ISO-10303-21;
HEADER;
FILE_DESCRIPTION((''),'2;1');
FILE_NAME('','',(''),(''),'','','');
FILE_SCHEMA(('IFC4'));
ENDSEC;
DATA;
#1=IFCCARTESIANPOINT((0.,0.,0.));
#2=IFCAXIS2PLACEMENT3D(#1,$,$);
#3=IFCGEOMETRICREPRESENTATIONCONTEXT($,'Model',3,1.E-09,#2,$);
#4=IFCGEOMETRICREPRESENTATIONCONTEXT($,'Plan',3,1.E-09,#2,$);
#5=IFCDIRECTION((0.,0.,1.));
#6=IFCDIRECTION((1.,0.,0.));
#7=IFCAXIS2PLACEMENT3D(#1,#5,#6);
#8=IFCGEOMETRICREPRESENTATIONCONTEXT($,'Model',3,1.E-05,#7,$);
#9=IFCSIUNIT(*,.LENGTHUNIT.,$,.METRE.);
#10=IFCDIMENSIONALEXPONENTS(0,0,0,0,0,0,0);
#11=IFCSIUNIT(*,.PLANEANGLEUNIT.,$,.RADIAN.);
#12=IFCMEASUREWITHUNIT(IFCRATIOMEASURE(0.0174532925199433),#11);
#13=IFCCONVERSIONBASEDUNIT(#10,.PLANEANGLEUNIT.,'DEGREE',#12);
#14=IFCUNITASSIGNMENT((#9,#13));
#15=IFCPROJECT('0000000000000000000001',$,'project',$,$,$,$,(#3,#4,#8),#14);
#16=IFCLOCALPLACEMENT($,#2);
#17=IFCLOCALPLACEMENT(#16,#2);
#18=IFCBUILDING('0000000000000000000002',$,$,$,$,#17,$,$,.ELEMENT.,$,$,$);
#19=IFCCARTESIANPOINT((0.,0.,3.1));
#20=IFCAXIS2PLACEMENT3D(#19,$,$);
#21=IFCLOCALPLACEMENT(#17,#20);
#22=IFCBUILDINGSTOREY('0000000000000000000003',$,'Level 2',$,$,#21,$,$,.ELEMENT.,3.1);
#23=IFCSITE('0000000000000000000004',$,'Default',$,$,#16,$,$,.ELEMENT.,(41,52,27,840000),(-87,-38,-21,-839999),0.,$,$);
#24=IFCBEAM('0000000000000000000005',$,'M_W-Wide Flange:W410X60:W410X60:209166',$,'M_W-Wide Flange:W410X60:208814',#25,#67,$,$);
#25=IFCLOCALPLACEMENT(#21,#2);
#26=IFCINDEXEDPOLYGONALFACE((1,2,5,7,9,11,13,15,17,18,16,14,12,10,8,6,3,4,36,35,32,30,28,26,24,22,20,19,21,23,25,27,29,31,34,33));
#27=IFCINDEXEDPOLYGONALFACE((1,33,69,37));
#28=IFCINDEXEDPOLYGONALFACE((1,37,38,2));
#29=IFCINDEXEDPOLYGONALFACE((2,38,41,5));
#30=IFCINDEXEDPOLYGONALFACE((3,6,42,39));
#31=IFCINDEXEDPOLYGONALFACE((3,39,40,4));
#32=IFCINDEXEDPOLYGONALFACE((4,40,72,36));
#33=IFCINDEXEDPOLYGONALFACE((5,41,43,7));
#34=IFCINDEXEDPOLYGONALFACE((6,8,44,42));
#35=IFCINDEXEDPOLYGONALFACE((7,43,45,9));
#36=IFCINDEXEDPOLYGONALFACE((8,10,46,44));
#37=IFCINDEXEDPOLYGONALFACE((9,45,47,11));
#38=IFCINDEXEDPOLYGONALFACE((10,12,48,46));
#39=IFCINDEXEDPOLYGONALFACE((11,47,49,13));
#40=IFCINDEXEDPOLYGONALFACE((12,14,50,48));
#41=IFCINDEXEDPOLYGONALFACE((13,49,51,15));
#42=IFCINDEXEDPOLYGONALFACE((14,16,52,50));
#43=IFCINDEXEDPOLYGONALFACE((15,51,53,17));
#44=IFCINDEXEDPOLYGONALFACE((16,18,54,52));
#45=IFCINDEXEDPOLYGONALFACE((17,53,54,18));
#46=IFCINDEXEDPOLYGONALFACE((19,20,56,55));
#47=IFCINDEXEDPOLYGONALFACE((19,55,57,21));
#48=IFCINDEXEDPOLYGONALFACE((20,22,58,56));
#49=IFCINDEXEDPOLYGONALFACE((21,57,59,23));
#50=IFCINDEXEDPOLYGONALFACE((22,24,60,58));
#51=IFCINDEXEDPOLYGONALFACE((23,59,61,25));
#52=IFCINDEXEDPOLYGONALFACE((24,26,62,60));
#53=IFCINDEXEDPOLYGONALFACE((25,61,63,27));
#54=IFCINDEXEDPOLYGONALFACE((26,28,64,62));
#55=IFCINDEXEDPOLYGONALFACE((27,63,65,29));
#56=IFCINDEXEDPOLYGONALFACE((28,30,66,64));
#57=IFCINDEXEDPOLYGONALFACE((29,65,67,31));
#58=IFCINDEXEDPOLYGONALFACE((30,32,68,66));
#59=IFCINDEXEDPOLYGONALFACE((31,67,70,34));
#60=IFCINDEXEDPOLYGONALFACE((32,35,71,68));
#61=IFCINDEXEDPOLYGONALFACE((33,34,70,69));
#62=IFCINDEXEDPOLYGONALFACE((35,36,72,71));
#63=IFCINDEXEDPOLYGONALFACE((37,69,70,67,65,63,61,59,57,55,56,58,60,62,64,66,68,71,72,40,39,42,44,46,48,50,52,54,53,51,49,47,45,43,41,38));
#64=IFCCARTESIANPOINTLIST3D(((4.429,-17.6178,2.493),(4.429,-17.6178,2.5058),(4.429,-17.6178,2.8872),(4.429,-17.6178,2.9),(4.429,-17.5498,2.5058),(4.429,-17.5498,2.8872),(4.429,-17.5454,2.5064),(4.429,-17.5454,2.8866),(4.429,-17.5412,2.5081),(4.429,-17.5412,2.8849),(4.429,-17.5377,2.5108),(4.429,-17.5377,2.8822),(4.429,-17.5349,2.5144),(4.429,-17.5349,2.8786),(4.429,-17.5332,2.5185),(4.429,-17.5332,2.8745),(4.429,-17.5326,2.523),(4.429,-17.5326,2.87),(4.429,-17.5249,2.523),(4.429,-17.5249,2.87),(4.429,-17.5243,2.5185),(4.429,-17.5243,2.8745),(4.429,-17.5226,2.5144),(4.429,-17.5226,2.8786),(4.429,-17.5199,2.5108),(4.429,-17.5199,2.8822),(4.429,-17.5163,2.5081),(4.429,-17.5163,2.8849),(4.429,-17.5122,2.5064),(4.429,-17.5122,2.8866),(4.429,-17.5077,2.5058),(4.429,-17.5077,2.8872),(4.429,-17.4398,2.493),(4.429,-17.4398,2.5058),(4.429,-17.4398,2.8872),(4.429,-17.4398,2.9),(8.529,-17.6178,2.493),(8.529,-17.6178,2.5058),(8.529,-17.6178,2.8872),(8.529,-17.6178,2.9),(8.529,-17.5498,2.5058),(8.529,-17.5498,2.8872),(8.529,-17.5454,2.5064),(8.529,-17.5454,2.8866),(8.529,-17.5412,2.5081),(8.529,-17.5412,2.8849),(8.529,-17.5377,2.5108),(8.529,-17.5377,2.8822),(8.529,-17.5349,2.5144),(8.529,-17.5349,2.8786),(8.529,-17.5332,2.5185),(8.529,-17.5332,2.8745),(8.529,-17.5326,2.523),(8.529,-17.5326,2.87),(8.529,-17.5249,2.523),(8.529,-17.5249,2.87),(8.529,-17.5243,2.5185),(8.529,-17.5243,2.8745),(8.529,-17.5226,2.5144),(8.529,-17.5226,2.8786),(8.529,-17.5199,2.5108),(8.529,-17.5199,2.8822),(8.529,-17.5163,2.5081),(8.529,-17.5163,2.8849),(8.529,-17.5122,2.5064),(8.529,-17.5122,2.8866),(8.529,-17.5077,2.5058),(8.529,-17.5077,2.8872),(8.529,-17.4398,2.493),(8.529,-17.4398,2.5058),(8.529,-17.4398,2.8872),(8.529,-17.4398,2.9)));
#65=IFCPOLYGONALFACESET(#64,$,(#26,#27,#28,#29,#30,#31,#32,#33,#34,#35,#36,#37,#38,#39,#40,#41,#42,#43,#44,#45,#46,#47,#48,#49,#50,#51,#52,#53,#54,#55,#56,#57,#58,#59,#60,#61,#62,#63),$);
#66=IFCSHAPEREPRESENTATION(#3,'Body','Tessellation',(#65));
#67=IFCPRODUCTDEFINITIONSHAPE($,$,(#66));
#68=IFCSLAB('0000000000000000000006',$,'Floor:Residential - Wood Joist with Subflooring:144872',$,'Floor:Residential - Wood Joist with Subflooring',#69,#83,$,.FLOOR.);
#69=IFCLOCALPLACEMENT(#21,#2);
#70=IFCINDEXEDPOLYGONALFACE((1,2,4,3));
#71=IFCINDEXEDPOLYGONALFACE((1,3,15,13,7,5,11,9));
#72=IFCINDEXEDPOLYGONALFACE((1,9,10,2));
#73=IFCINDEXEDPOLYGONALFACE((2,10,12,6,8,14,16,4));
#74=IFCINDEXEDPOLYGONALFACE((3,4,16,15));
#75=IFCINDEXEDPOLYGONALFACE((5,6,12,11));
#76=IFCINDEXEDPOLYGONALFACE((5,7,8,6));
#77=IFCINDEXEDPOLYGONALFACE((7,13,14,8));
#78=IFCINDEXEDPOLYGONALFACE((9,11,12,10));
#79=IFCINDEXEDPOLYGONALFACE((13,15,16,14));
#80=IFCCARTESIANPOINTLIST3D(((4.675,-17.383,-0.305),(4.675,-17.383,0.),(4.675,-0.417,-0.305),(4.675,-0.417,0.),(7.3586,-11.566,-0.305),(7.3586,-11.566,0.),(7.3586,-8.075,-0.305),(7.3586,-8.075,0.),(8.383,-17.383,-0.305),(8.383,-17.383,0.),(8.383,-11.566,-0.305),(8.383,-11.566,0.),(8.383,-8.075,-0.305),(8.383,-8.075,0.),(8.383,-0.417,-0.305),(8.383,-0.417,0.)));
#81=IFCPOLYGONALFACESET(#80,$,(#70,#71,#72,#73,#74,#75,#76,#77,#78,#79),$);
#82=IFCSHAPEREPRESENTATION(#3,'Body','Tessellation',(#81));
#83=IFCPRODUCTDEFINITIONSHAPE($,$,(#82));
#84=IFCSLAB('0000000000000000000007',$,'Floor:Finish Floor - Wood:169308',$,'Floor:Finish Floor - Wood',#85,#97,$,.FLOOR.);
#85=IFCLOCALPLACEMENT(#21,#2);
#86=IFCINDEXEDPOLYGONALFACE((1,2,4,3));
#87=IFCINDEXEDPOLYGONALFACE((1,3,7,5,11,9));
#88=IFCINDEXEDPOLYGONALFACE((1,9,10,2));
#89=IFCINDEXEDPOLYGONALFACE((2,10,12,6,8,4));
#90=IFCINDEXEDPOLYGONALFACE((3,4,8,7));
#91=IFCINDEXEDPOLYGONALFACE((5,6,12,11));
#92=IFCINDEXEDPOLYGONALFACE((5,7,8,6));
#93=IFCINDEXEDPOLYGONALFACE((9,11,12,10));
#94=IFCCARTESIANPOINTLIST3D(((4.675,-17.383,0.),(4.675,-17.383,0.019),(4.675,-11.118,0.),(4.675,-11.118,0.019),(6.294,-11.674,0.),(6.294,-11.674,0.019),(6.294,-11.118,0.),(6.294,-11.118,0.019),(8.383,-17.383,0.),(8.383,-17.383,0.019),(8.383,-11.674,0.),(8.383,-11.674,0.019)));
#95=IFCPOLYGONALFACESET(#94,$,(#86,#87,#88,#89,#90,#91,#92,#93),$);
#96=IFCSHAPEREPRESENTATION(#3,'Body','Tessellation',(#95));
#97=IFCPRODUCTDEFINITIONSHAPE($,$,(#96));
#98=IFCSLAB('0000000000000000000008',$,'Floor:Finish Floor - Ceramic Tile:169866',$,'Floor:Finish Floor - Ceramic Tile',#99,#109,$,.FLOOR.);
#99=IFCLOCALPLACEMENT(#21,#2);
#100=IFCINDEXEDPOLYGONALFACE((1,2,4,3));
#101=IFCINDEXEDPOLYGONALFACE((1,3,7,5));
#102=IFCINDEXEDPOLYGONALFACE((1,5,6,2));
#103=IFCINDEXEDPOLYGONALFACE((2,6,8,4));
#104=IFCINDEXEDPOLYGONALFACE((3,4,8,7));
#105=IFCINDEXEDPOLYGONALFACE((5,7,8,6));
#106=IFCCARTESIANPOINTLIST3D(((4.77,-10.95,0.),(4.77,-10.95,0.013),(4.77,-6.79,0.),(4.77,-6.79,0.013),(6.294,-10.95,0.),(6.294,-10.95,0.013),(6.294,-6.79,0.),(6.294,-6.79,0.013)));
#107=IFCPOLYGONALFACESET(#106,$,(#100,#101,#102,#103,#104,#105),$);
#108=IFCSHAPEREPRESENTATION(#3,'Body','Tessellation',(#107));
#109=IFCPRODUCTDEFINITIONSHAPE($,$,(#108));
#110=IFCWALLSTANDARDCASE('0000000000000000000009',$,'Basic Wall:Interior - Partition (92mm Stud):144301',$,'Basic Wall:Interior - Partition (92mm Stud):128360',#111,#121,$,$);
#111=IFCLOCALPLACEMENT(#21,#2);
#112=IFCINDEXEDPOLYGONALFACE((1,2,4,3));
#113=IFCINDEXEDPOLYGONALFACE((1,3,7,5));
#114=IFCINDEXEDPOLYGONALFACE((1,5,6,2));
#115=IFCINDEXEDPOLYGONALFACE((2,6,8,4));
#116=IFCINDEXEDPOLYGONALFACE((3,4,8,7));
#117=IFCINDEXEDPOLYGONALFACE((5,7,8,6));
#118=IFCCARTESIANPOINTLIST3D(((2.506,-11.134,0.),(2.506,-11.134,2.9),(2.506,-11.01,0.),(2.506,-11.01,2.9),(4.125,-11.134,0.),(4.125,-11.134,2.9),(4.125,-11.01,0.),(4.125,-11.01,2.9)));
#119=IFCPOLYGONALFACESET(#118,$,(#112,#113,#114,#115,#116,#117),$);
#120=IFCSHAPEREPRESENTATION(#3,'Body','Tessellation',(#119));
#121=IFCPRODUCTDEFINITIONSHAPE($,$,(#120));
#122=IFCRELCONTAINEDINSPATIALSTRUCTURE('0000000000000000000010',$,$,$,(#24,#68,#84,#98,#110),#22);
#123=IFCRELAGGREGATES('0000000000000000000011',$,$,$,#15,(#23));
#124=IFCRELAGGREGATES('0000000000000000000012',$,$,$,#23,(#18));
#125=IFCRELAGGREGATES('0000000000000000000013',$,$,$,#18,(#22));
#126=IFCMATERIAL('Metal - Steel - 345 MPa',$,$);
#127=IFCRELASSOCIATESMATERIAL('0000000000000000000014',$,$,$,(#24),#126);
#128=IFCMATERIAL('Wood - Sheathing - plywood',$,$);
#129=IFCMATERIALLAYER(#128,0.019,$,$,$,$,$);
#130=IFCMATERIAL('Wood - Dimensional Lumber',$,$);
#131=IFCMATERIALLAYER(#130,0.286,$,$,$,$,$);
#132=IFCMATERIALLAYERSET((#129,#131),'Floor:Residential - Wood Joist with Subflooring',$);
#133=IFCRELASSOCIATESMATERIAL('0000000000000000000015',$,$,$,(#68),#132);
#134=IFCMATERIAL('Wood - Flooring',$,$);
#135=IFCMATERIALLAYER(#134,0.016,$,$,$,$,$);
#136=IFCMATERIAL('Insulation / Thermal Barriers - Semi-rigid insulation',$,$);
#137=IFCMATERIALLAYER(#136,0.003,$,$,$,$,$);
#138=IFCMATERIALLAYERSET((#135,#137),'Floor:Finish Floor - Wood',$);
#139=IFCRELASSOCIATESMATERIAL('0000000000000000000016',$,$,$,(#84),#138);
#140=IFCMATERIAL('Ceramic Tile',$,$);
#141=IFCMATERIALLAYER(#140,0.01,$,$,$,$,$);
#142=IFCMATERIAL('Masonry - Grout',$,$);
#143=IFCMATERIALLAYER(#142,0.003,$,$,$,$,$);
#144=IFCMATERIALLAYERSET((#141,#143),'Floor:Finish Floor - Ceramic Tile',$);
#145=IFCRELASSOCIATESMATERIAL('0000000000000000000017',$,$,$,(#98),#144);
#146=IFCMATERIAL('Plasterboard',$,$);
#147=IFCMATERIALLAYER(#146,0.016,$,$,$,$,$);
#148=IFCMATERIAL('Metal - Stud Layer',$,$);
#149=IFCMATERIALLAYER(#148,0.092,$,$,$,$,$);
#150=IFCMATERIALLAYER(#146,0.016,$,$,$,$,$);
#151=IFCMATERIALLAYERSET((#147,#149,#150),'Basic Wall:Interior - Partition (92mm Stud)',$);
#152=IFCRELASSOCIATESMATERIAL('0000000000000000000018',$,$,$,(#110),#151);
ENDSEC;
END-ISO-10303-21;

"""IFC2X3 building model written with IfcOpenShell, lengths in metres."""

from ifc_helpers import new_model, entity, si_unit, converted_unit, frame, frame_2d, origin, origin_with_axes, place, context, project, spatial, polyline, circle_curve, parameter, trimmed, segment, composite_curve, rectangle, outline, extrude, material, layer, layer_set, layer_usage, element, save


model = new_model("IFC2X3")

# Units and contexts
model_context_1 = context("Model", 3, precision=1e-09, world=origin())
plan_context = context("Plan", 3, precision=1e-09, world=origin())
model_context_2 = context("Model", 3, precision=1e-05, world=origin_with_axes())
ifc_project = project(units=[si_unit("LENGTHUNIT", "METRE"), converted_unit("PLANEANGLEUNIT", "DEGREE", entity("IfcRatioMeasure", 0.0174532925199433), si_unit("PLANEANGLEUNIT", "RADIAN"), dimensions=[0, 0, 0, 0, 0, 0, 0])], contexts=[model_context_1, plan_context, model_context_2])

# Site, building, storey
site_placement = place(None, origin())
site = spatial("IfcSite", under=ifc_project, at=site_placement, Name="Default", CompositionType="ELEMENT", RefLatitude=(41, 52, 27, 840000), RefLongitude=(-87, -38, -21, -839999), RefElevation=0.0)
building_placement = place(site_placement, origin())
building = spatial("IfcBuilding", under=site, at=building_placement, CompositionType="ELEMENT")
storey_placement = place(building_placement, frame((0.0, 0.0, 3.1)))
storey = spatial("IfcBuildingStorey", under=building, at=storey_placement, Name="Level 2", CompositionType="ELEMENT", Elevation=3.1)

# Beam
ifc_material_1 = material(Name="Metal - Steel - 345 MPa")
beam_placement = place(storey_placement, frame((4.429, -17.5288, 2.9), z_axis=(0.0, 0.0, 1.0), x_axis=(0.0, -1.0, 0.0)))
element("IfcBeam", 1, at=beam_placement, inside=storey, material=ifc_material_1, Name="M_W-Wide Flange:W410X60:W410X60:209166", ObjectType="M_W-Wide Flange:W410X60:208814", context=model_context_1, shape_type="SweptSolid", body=[
    extrude(outline(composite_curve([segment(polyline([(-0.089, -0.1907), (-0.089, -0.2035)]), True, "CONTINUOUS"), segment(polyline([(-0.089, -0.2035), (0.089, -0.2035)]), True, "CONTINUOUS"), segment(polyline([(0.089, -0.2035), (0.089, -0.1907)]), True, "CONTINUOUS"), segment(polyline([(0.089, -0.1907), (0.021, -0.1907)]), True, "CONTINUOUS"), segment(trimmed(circle_curve(frame_2d((0.021, -0.1735), x_axis=(0.0, -1.0)), 0.0172), [parameter(270.0)], [parameter(360.0)], True, "PARAMETER"), False, "CONTINUOUS"), segment(polyline([(0.0038, -0.1735), (0.0038, 0.1735)]), True, "CONTINUOUS"), segment(trimmed(circle_curve(frame_2d((0.021, 0.1735), x_axis=(-1.0, 0.0)), 0.0172), [parameter(270.0)], [parameter(360.0)], True, "PARAMETER"), False, "CONTINUOUS"), segment(polyline([(0.021, 0.1907), (0.089, 0.1907)]), True, "CONTINUOUS"), segment(polyline([(0.089, 0.1907), (0.089, 0.2035)]), True, "CONTINUOUS"), segment(polyline([(0.089, 0.2035), (-0.089, 0.2035)]), True, "CONTINUOUS"), segment(polyline([(-0.089, 0.2035), (-0.089, 0.1907)]), True, "CONTINUOUS"), segment(polyline([(-0.089, 0.1907), (-0.0211, 0.1907)]), True, "CONTINUOUS"), segment(trimmed(circle_curve(frame_2d((-0.0211, 0.1735), x_axis=(0.0, 1.0)), 0.0172), [parameter(270.0)], [parameter(0.0)], True, "PARAMETER"), False, "CONTINUOUS"), segment(polyline([(-0.0039, 0.1735), (-0.0039, -0.1735)]), True, "CONTINUOUS"), segment(trimmed(circle_curve(frame_2d((-0.0211, -0.1735), x_axis=(1.0, 0.0)), 0.0172), [parameter(270.0)], [parameter(0.0)], True, "PARAMETER"), False, "CONTINUOUS"), segment(polyline([(-0.0211, -0.1907), (-0.089, -0.1907)]), True, "CONTINUOUS")], self_intersect=False)), frame((0.0, 0.0, -0.2035), z_axis=(0.0, -1.0, 0.0), x_axis=(1.0, 0.0, 0.0)), (0.0, 0.0, -1.0), 4.1),
])

# Slabs
ifc_material_2 = material(Name="Wood - Sheathing - plywood")
ifc_layer_1 = layer(ifc_material_2, 0.019)
ifc_material_3 = material(Name="Wood - Dimensional Lumber")
ifc_layer_2 = layer(ifc_material_3, 0.286)
ifc_layer_set_1 = layer_set([ifc_layer_1, ifc_layer_2], Name="Floor:Residential - Wood Joist with Subflooring")
ifc_layer_usage_1 = layer_usage(ifc_layer_set_1, "AXIS3", "POSITIVE", 0.0)
slab_1_placement = place(storey_placement, frame((4.675, -17.383, -0.305)))
element("IfcSlab", 2, at=slab_1_placement, inside=storey, material=ifc_layer_usage_1, Name="Floor:Residential - Wood Joist with Subflooring:144872", ObjectType="Floor:Residential - Wood Joist with Subflooring", PredefinedType="FLOOR", context=model_context_1, shape_type="SweptSolid", body=[
    extrude(outline(polyline([(-1.854, 8.483), (-1.854, 0.825), (-0.8296, 0.825), (-0.8296, -2.666), (-1.854, -2.666), (-1.854, -8.483), (1.854, -8.483), (1.854, 8.483), (-1.854, 8.483)])), frame((1.854, 8.483, 0.305), z_axis=(0.0, 0.0, -1.0), x_axis=(-1.0, 0.0, 0.0)), (0.0, 0.0, 1.0), 0.305),
])
ifc_material_4 = material(Name="Wood - Flooring")
ifc_layer_3 = layer(ifc_material_4, 0.016)
ifc_material_5 = material(Name="Insulation / Thermal Barriers - Semi-rigid insulation")
ifc_layer_4 = layer(ifc_material_5, 0.003)
ifc_layer_set_2 = layer_set([ifc_layer_3, ifc_layer_4], Name="Floor:Finish Floor - Wood")
ifc_layer_usage_2 = layer_usage(ifc_layer_set_2, "AXIS3", "POSITIVE", 0.0)
slab_2_placement = place(storey_placement, frame((4.675, -17.383, 0.0)))
element("IfcSlab", 3, at=slab_2_placement, inside=storey, material=ifc_layer_usage_2, Name="Floor:Finish Floor - Wood:169308", ObjectType="Floor:Finish Floor - Wood", PredefinedType="FLOOR", context=model_context_1, shape_type="SweptSolid", body=[
    extrude(outline(polyline([(-1.854, 2.5765), (-1.854, -3.1325), (1.854, -3.1325), (1.854, 3.1325), (0.235, 3.1325), (0.235, 2.5765), (-1.854, 2.5765)])), frame((1.854, 3.1325, 0.019), z_axis=(0.0, 0.0, -1.0), x_axis=(-1.0, 0.0, 0.0)), (0.0, 0.0, 1.0), 0.019),
])
ifc_material_6 = material(Name="Ceramic Tile")
ifc_layer_5 = layer(ifc_material_6, 0.01)
ifc_material_7 = material(Name="Masonry - Grout")
ifc_layer_6 = layer(ifc_material_7, 0.003)
ifc_layer_set_3 = layer_set([ifc_layer_5, ifc_layer_6], Name="Floor:Finish Floor - Ceramic Tile")
ifc_layer_usage_3 = layer_usage(ifc_layer_set_3, "AXIS3", "POSITIVE", 0.0)
slab_3_placement = place(storey_placement, frame((4.77, -10.95, 0.0)))
element("IfcSlab", 4, at=slab_3_placement, inside=storey, material=ifc_layer_usage_3, Name="Floor:Finish Floor - Ceramic Tile:169866", ObjectType="Floor:Finish Floor - Ceramic Tile", PredefinedType="FLOOR", context=model_context_1, shape_type="SweptSolid", body=[
    extrude(rectangle(XDim=4.16, YDim=1.524, at=frame_2d((0.0, 0.0), x_axis=(0.0, -1.0))), frame((0.762, 2.08, 0.013), z_axis=(0.0, 0.0, -1.0), x_axis=(-1.0, 0.0, 0.0)), (0.0, 0.0, 1.0), 0.013),
])

# Shared definitions
ifc_material_8 = material(Name="Metal - Stud Layer")
ifc_material_9 = material(Name="Plasterboard")

# Wall
ifc_layer_7 = layer(ifc_material_9, 0.016)
ifc_layer_8 = layer(ifc_material_8, 0.092)
ifc_layer_9 = layer(ifc_material_9, 0.016)
ifc_layer_set_4 = layer_set([ifc_layer_7, ifc_layer_8, ifc_layer_9], Name="Basic Wall:Interior - Partition (92mm Stud)")
ifc_layer_usage_4 = layer_usage(ifc_layer_set_4, "AXIS2", "NEGATIVE", 0.062)
wall_1_placement = place(storey_placement, frame((4.125, -11.072, 0.0), z_axis=(0.0, 0.0, 1.0), x_axis=(-1.0, 0.0, 0.0)))
element("IfcWallStandardCase", 5, at=wall_1_placement, inside=storey, material=ifc_layer_usage_4, Name="Basic Wall:Interior - Partition (92mm Stud):144301", ObjectType="Basic Wall:Interior - Partition (92mm Stud):128360", context=model_context_1, shape_type="SweptSolid", body=[
    extrude(rectangle(XDim=1.619, YDim=0.124, at=frame_2d((0.8095, 0.0), x_axis=(-1.0, 0.0))), origin(), (0.0, 0.0, 1.0), 2.9),
])

save(model, "model.ifc")
